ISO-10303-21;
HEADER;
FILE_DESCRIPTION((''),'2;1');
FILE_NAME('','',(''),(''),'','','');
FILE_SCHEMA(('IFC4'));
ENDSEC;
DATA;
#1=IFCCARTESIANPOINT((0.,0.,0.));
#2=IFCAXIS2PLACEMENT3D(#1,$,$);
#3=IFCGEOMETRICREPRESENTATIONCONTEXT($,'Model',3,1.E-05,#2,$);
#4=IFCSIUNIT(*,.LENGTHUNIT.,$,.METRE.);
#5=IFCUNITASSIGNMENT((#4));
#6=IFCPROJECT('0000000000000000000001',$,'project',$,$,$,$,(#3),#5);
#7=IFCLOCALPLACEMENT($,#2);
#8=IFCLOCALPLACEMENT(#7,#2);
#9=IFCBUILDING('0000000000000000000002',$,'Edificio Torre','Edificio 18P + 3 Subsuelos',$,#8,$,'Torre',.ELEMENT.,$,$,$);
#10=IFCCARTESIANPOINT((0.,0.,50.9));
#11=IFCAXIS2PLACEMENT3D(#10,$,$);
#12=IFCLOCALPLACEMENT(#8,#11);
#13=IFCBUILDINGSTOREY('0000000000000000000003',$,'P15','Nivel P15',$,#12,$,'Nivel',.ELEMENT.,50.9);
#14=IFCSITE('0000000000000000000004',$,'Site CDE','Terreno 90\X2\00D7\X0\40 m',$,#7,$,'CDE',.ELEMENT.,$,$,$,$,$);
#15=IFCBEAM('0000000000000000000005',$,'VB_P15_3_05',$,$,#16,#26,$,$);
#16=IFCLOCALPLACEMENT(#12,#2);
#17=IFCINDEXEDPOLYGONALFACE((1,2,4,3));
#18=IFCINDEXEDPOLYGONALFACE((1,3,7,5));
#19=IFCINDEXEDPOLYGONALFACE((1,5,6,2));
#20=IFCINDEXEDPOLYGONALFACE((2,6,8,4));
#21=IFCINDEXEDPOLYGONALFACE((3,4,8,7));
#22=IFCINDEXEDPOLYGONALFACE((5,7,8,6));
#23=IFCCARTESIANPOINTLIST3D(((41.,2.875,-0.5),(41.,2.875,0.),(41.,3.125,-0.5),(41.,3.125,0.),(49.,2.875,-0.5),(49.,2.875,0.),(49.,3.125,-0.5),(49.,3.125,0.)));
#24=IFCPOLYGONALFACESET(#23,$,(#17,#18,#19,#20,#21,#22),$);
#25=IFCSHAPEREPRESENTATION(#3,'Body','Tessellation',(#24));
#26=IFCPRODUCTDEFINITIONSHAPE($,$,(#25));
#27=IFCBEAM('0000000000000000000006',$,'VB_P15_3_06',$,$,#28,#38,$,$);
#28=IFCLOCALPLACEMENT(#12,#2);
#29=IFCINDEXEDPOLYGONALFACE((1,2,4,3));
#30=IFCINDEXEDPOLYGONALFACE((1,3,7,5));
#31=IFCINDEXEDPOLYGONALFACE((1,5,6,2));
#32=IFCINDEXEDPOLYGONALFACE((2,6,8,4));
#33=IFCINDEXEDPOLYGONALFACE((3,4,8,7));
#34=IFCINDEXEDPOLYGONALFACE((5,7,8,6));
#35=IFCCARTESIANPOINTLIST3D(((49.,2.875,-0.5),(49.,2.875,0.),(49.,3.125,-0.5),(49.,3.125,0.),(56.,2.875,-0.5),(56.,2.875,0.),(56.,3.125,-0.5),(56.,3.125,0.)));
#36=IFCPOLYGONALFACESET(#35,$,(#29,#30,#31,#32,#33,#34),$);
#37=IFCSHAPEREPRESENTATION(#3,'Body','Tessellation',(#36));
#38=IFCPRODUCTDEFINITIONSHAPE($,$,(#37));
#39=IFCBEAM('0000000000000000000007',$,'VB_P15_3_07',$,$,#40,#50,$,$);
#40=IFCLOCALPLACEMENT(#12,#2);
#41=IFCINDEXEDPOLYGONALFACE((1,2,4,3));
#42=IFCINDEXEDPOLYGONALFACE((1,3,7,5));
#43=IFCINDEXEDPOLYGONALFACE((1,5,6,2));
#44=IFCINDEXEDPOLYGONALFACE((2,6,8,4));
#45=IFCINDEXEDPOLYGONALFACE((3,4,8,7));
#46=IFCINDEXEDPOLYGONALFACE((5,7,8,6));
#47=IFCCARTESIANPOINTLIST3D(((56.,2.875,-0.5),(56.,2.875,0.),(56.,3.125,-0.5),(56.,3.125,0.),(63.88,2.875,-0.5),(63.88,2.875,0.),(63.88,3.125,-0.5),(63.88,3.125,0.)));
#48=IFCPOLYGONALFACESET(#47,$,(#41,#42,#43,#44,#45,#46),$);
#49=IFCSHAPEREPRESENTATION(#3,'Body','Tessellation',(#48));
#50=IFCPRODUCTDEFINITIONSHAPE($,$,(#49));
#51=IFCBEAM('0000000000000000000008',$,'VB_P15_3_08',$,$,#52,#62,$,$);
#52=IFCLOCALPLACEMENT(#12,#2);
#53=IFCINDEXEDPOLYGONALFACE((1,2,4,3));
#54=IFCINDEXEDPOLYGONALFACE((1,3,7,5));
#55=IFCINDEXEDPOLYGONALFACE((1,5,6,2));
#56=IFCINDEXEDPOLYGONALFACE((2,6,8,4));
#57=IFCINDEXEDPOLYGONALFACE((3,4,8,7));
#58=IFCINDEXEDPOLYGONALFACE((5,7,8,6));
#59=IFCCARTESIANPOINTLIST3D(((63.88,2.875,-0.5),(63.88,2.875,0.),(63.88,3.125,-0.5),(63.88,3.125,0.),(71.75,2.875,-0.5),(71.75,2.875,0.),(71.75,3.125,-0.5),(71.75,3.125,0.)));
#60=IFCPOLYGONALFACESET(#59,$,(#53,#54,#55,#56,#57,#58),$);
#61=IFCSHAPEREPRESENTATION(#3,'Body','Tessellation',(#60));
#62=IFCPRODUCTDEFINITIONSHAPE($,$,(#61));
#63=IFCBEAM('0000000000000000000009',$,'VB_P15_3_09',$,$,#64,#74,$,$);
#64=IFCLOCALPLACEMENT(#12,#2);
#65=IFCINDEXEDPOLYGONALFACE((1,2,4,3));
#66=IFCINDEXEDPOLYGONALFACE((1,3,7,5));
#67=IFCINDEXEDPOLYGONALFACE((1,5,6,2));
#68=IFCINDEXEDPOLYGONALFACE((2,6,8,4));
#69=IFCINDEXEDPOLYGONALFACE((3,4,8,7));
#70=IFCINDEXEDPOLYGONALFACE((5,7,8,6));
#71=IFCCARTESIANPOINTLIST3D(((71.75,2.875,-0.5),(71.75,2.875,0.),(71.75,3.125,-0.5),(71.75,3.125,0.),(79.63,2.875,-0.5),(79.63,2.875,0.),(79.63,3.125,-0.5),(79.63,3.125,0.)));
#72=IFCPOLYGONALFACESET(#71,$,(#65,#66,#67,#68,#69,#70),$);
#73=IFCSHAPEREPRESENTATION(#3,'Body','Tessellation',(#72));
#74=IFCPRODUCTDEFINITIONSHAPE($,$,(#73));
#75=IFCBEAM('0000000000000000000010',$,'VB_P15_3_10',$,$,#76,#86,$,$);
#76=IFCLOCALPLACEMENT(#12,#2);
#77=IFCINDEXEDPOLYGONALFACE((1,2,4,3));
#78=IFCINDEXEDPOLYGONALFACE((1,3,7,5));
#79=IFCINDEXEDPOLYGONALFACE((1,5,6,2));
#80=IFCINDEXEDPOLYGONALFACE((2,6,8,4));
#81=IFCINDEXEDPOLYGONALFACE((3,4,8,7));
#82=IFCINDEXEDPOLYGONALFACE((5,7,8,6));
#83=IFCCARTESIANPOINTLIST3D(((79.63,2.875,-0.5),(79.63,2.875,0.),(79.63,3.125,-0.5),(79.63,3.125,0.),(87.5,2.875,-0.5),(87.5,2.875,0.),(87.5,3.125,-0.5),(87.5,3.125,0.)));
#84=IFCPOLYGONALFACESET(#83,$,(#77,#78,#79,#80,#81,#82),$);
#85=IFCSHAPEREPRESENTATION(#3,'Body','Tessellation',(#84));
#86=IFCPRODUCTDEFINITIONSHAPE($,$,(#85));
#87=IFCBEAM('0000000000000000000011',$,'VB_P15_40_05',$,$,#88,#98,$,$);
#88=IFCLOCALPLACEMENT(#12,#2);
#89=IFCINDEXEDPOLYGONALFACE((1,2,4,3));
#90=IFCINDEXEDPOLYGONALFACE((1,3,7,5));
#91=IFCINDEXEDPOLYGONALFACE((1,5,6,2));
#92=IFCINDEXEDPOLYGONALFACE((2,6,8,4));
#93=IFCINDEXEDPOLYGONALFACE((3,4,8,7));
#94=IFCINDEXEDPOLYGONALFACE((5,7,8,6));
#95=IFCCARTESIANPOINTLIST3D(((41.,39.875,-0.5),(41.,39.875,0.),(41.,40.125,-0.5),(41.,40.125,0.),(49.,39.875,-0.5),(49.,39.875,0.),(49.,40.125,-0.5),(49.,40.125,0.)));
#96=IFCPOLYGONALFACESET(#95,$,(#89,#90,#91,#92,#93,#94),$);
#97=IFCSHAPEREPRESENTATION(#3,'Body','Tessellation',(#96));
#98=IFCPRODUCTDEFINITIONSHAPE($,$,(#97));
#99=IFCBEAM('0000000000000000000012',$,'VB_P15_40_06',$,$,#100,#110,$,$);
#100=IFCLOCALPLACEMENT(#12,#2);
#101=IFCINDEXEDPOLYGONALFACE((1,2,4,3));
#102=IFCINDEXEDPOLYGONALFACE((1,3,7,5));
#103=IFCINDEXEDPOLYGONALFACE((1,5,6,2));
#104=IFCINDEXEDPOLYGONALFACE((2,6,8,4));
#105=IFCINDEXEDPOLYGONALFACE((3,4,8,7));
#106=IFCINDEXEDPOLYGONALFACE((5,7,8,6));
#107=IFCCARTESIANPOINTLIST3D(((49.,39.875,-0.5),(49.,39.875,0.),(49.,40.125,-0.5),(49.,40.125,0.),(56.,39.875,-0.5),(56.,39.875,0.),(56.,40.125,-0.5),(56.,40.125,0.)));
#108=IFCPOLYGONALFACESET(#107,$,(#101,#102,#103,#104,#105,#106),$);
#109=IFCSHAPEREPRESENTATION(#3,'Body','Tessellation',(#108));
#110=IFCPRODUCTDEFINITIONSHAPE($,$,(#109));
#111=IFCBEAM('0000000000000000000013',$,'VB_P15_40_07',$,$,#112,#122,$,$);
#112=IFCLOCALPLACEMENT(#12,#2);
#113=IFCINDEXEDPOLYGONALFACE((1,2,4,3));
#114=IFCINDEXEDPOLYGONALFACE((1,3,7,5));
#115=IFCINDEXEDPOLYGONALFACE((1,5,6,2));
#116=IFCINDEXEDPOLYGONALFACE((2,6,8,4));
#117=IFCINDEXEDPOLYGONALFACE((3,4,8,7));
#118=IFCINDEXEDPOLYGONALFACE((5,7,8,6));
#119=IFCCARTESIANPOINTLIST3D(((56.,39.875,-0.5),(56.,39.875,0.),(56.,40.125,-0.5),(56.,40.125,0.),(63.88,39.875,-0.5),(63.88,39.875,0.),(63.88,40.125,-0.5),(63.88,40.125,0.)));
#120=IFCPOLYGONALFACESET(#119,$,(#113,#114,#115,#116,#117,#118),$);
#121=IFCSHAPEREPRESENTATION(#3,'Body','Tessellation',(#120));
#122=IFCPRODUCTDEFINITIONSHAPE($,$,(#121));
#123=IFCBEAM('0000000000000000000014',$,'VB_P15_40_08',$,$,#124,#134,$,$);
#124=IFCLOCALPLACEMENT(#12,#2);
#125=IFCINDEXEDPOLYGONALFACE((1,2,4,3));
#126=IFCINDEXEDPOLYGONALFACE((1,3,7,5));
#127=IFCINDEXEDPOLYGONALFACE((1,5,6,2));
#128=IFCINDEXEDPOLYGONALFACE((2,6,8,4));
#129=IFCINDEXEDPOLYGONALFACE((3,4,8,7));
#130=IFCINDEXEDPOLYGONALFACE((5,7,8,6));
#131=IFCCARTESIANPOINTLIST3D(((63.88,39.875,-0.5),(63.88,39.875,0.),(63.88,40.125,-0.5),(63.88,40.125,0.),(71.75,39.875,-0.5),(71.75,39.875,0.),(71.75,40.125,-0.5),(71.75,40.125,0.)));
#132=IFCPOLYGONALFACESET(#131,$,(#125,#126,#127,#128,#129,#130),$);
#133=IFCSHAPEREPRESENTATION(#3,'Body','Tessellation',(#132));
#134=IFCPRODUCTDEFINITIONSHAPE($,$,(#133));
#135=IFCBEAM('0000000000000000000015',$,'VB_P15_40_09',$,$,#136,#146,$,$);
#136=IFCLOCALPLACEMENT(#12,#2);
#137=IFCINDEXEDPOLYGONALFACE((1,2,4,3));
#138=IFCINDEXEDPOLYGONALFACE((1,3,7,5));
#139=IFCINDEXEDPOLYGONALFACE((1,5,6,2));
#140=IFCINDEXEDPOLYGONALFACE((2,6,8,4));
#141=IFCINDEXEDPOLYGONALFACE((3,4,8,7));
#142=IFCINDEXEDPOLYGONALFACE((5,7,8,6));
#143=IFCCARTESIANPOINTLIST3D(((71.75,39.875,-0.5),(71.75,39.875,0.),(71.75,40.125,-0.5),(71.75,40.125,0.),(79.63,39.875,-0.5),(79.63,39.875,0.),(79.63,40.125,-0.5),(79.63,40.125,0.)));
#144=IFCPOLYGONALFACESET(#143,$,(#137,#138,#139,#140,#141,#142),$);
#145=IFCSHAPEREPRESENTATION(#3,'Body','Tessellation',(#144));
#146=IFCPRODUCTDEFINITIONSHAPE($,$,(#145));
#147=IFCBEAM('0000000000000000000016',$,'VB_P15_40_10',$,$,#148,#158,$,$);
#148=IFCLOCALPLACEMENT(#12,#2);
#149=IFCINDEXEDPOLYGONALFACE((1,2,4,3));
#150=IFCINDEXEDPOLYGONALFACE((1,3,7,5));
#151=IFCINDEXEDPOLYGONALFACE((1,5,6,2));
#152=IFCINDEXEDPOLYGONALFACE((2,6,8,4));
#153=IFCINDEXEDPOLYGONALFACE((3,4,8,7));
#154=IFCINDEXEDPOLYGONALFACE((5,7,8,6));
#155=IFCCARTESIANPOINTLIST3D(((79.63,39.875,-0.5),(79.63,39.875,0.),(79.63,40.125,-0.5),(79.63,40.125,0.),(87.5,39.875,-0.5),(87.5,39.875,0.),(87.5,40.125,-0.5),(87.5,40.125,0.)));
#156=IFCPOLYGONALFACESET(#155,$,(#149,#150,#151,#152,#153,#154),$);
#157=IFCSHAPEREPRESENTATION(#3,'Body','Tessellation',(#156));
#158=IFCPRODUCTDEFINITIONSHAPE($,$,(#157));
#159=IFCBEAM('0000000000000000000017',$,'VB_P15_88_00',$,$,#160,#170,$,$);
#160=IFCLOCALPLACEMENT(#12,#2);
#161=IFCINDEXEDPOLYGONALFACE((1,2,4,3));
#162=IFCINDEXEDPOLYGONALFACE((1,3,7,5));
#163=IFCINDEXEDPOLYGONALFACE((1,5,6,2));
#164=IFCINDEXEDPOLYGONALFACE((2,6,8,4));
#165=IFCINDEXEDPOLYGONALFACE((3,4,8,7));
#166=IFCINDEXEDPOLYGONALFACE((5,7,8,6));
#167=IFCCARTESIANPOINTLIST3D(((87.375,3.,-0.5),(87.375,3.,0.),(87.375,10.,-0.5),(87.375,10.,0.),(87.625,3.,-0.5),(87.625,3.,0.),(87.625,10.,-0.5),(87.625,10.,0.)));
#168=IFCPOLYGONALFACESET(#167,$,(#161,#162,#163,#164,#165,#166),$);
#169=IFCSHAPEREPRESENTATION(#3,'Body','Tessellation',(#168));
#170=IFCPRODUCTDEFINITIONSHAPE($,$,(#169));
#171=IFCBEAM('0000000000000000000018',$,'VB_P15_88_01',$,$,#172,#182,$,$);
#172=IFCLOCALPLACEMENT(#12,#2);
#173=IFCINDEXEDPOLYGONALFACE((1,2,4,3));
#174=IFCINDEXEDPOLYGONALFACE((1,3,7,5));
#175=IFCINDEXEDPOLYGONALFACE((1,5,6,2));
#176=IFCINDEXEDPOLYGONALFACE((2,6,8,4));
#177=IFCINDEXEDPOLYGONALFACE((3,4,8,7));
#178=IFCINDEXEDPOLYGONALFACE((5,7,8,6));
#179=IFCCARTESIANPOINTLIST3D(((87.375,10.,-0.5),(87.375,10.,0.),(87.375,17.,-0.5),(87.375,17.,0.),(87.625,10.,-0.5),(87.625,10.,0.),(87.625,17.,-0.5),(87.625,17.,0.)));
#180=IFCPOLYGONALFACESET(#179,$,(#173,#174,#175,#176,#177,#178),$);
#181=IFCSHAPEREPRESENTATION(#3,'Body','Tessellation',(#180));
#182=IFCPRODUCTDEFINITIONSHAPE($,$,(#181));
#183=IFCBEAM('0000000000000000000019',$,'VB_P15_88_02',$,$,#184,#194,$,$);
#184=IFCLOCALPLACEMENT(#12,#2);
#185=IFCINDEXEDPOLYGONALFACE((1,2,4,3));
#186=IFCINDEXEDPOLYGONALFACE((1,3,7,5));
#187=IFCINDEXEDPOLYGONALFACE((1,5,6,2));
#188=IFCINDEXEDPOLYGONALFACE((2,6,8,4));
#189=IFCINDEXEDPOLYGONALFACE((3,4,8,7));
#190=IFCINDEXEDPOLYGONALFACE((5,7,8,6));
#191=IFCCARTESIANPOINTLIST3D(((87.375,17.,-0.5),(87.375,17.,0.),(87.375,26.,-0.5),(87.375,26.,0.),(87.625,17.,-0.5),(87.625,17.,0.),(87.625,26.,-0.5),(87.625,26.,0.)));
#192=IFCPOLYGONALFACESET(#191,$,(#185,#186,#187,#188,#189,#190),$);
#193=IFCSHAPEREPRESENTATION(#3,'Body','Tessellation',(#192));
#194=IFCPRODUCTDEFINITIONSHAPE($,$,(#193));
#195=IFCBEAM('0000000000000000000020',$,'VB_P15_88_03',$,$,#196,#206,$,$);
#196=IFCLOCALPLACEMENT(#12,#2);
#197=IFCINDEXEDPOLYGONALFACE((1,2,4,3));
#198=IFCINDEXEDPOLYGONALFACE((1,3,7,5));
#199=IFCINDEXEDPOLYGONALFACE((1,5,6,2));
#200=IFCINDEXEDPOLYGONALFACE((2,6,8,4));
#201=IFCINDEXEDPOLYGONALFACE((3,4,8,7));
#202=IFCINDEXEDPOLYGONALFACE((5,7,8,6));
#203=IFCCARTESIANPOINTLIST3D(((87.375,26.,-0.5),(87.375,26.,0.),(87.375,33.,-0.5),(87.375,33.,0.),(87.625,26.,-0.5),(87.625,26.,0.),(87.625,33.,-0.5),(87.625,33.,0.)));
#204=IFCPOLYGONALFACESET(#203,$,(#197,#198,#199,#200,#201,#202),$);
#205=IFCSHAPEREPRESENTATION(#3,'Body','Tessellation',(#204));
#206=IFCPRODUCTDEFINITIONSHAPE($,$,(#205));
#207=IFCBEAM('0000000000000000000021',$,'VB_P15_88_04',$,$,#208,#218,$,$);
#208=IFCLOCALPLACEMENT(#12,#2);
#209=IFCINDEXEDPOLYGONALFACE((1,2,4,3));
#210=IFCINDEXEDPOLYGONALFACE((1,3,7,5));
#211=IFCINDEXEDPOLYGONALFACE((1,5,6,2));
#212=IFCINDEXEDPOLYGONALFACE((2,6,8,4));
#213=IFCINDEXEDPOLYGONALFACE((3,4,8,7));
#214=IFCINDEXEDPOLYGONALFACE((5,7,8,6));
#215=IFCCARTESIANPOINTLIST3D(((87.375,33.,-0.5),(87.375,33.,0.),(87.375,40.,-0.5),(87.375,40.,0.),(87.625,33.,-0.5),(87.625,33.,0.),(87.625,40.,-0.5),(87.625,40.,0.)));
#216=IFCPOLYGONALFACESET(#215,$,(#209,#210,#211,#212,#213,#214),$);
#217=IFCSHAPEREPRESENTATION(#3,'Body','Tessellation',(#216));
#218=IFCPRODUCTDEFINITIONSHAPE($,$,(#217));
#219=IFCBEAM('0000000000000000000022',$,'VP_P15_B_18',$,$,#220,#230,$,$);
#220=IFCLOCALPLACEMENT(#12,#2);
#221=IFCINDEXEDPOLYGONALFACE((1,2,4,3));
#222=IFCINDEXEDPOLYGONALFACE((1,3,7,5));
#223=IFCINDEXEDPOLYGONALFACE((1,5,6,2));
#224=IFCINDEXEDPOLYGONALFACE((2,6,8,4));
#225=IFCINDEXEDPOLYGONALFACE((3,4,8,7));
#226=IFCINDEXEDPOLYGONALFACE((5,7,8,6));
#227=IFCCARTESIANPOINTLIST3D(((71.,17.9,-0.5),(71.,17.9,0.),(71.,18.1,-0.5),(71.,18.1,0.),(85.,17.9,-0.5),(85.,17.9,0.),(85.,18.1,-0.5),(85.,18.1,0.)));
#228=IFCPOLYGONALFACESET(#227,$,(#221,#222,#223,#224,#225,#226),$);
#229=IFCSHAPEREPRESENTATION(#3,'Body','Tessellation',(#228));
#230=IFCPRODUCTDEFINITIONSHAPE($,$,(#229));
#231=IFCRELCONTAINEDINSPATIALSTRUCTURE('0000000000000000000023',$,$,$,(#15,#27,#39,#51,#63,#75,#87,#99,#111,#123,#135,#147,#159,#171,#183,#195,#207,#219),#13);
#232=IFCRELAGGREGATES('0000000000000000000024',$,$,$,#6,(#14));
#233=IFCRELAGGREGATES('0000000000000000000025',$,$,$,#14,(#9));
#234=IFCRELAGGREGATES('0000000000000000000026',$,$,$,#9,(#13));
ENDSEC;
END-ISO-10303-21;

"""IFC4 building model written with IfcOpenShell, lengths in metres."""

from ifc_helpers import new_model, si_unit, frame, origin, origin_2d, place, context, project, spatial, rectangle, extrude, element, save


model = new_model("IFC4")

# Units and contexts
model_context = context("Model", 3, precision=1e-05, world=origin())
ifc_project = project(units=[si_unit("LENGTHUNIT", "METRE")], contexts=[model_context])

# Site, building, storey
site_placement = place(None, origin())
site = spatial("IfcSite", under=ifc_project, at=site_placement, Name="Site CDE", Description="Terreno 90×40 m", LongName="CDE", CompositionType="ELEMENT")
building_placement = place(site_placement, origin())
building = spatial("IfcBuilding", under=site, at=building_placement, Name="Edificio Torre", Description="Edificio 18P + 3 Subsuelos", LongName="Torre", CompositionType="ELEMENT")
storey_placement = place(building_placement, frame((0.0, 0.0, 50.9)))
storey = spatial("IfcBuildingStorey", under=building, at=storey_placement, Name="P15", Description="Nivel P15", LongName="Nivel", CompositionType="ELEMENT", Elevation=50.9)

# Beams
beam_1_placement = place(storey_placement, frame((45.0, 3.0, -0.5)))
element("IfcBeam", 1, at=beam_1_placement, inside=storey, Name="VB_P15_3_05", context=model_context, shape_type="SweptSolid", body=[
    extrude(rectangle(XDim=8.0, YDim=0.25, at=origin_2d()), origin(), (0.0, 0.0, 1.0), 0.5),
])
beam_2_placement = place(storey_placement, frame((52.5, 3.0, -0.5)))
element("IfcBeam", 2, at=beam_2_placement, inside=storey, Name="VB_P15_3_06", context=model_context, shape_type="SweptSolid", body=[
    extrude(rectangle(XDim=7.0, YDim=0.25, at=origin_2d()), origin(), (0.0, 0.0, 1.0), 0.5),
])
beam_3_placement = place(storey_placement, frame((59.94, 3.0, -0.5)))
element("IfcBeam", 3, at=beam_3_placement, inside=storey, Name="VB_P15_3_07", context=model_context, shape_type="SweptSolid", body=[
    extrude(rectangle(XDim=7.88, YDim=0.25, at=origin_2d()), origin(), (0.0, 0.0, 1.0), 0.5),
])
beam_4_placement = place(storey_placement, frame((67.815, 3.0, -0.5)))
element("IfcBeam", 4, at=beam_4_placement, inside=storey, Name="VB_P15_3_08", context=model_context, shape_type="SweptSolid", body=[
    extrude(rectangle(XDim=7.87, YDim=0.25, at=origin_2d()), origin(), (0.0, 0.0, 1.0), 0.5),
])
beam_5_placement = place(storey_placement, frame((75.69, 3.0, -0.5)))
element("IfcBeam", 5, at=beam_5_placement, inside=storey, Name="VB_P15_3_09", context=model_context, shape_type="SweptSolid", body=[
    extrude(rectangle(XDim=7.88, YDim=0.25, at=origin_2d()), origin(), (0.0, 0.0, 1.0), 0.5),
])
beam_6_placement = place(storey_placement, frame((83.565, 3.0, -0.5)))
element("IfcBeam", 6, at=beam_6_placement, inside=storey, Name="VB_P15_3_10", context=model_context, shape_type="SweptSolid", body=[
    extrude(rectangle(XDim=7.87, YDim=0.25, at=origin_2d()), origin(), (0.0, 0.0, 1.0), 0.5),
])
beam_7_placement = place(storey_placement, frame((45.0, 40.0, -0.5)))
element("IfcBeam", 7, at=beam_7_placement, inside=storey, Name="VB_P15_40_05", context=model_context, shape_type="SweptSolid", body=[
    extrude(rectangle(XDim=8.0, YDim=0.25, at=origin_2d()), origin(), (0.0, 0.0, 1.0), 0.5),
])
beam_8_placement = place(storey_placement, frame((52.5, 40.0, -0.5)))
element("IfcBeam", 8, at=beam_8_placement, inside=storey, Name="VB_P15_40_06", context=model_context, shape_type="SweptSolid", body=[
    extrude(rectangle(XDim=7.0, YDim=0.25, at=origin_2d()), origin(), (0.0, 0.0, 1.0), 0.5),
])
beam_9_placement = place(storey_placement, frame((59.94, 40.0, -0.5)))
element("IfcBeam", 9, at=beam_9_placement, inside=storey, Name="VB_P15_40_07", context=model_context, shape_type="SweptSolid", body=[
    extrude(rectangle(XDim=7.88, YDim=0.25, at=origin_2d()), origin(), (0.0, 0.0, 1.0), 0.5),
])
beam_10_placement = place(storey_placement, frame((67.815, 40.0, -0.5)))
element("IfcBeam", 10, at=beam_10_placement, inside=storey, Name="VB_P15_40_08", context=model_context, shape_type="SweptSolid", body=[
    extrude(rectangle(XDim=7.87, YDim=0.25, at=origin_2d()), origin(), (0.0, 0.0, 1.0), 0.5),
])
beam_11_placement = place(storey_placement, frame((75.69, 40.0, -0.5)))
element("IfcBeam", 11, at=beam_11_placement, inside=storey, Name="VB_P15_40_09", context=model_context, shape_type="SweptSolid", body=[
    extrude(rectangle(XDim=7.88, YDim=0.25, at=origin_2d()), origin(), (0.0, 0.0, 1.0), 0.5),
])
beam_12_placement = place(storey_placement, frame((83.565, 40.0, -0.5)))
element("IfcBeam", 12, at=beam_12_placement, inside=storey, Name="VB_P15_40_10", context=model_context, shape_type="SweptSolid", body=[
    extrude(rectangle(XDim=7.87, YDim=0.25, at=origin_2d()), origin(), (0.0, 0.0, 1.0), 0.5),
])
for number, where, name in (
    (13, (87.5, 6.5, -0.5), "VB_P15_88_00"),
    (14, (87.5, 13.5, -0.5), "VB_P15_88_01"),
):
    element("IfcBeam", number, at=place(storey_placement, frame(where)), inside=storey, Name=name, context=model_context, shape_type="SweptSolid", body=[
        extrude(rectangle(XDim=0.25, YDim=7.0, at=origin_2d()), origin(), (0.0, 0.0, 1.0), 0.5),
    ])
beam_13_placement = place(storey_placement, frame((87.5, 21.5, -0.5)))
element("IfcBeam", 15, at=beam_13_placement, inside=storey, Name="VB_P15_88_02", context=model_context, shape_type="SweptSolid", body=[
    extrude(rectangle(XDim=0.25, YDim=9.0, at=origin_2d()), origin(), (0.0, 0.0, 1.0), 0.5),
])
for number, where, name in (
    (16, (87.5, 29.5, -0.5), "VB_P15_88_03"),
    (17, (87.5, 36.5, -0.5), "VB_P15_88_04"),
):
    element("IfcBeam", number, at=place(storey_placement, frame(where)), inside=storey, Name=name, context=model_context, shape_type="SweptSolid", body=[
        extrude(rectangle(XDim=0.25, YDim=7.0, at=origin_2d()), origin(), (0.0, 0.0, 1.0), 0.5),
    ])
for number, where, name in (
    (18, (78.0, 18.0, -0.5), "VP_P15_B_18"),
):
    element("IfcBeam", number, at=place(storey_placement, frame(where)), inside=storey, Name=name, context=model_context, shape_type="SweptSolid", body=[
        extrude(rectangle(XDim=14.0, YDim=0.2, at=origin_2d()), origin(), (0.0, 0.0, 1.0), 0.5),
    ])

save(model, "model.ifc")
